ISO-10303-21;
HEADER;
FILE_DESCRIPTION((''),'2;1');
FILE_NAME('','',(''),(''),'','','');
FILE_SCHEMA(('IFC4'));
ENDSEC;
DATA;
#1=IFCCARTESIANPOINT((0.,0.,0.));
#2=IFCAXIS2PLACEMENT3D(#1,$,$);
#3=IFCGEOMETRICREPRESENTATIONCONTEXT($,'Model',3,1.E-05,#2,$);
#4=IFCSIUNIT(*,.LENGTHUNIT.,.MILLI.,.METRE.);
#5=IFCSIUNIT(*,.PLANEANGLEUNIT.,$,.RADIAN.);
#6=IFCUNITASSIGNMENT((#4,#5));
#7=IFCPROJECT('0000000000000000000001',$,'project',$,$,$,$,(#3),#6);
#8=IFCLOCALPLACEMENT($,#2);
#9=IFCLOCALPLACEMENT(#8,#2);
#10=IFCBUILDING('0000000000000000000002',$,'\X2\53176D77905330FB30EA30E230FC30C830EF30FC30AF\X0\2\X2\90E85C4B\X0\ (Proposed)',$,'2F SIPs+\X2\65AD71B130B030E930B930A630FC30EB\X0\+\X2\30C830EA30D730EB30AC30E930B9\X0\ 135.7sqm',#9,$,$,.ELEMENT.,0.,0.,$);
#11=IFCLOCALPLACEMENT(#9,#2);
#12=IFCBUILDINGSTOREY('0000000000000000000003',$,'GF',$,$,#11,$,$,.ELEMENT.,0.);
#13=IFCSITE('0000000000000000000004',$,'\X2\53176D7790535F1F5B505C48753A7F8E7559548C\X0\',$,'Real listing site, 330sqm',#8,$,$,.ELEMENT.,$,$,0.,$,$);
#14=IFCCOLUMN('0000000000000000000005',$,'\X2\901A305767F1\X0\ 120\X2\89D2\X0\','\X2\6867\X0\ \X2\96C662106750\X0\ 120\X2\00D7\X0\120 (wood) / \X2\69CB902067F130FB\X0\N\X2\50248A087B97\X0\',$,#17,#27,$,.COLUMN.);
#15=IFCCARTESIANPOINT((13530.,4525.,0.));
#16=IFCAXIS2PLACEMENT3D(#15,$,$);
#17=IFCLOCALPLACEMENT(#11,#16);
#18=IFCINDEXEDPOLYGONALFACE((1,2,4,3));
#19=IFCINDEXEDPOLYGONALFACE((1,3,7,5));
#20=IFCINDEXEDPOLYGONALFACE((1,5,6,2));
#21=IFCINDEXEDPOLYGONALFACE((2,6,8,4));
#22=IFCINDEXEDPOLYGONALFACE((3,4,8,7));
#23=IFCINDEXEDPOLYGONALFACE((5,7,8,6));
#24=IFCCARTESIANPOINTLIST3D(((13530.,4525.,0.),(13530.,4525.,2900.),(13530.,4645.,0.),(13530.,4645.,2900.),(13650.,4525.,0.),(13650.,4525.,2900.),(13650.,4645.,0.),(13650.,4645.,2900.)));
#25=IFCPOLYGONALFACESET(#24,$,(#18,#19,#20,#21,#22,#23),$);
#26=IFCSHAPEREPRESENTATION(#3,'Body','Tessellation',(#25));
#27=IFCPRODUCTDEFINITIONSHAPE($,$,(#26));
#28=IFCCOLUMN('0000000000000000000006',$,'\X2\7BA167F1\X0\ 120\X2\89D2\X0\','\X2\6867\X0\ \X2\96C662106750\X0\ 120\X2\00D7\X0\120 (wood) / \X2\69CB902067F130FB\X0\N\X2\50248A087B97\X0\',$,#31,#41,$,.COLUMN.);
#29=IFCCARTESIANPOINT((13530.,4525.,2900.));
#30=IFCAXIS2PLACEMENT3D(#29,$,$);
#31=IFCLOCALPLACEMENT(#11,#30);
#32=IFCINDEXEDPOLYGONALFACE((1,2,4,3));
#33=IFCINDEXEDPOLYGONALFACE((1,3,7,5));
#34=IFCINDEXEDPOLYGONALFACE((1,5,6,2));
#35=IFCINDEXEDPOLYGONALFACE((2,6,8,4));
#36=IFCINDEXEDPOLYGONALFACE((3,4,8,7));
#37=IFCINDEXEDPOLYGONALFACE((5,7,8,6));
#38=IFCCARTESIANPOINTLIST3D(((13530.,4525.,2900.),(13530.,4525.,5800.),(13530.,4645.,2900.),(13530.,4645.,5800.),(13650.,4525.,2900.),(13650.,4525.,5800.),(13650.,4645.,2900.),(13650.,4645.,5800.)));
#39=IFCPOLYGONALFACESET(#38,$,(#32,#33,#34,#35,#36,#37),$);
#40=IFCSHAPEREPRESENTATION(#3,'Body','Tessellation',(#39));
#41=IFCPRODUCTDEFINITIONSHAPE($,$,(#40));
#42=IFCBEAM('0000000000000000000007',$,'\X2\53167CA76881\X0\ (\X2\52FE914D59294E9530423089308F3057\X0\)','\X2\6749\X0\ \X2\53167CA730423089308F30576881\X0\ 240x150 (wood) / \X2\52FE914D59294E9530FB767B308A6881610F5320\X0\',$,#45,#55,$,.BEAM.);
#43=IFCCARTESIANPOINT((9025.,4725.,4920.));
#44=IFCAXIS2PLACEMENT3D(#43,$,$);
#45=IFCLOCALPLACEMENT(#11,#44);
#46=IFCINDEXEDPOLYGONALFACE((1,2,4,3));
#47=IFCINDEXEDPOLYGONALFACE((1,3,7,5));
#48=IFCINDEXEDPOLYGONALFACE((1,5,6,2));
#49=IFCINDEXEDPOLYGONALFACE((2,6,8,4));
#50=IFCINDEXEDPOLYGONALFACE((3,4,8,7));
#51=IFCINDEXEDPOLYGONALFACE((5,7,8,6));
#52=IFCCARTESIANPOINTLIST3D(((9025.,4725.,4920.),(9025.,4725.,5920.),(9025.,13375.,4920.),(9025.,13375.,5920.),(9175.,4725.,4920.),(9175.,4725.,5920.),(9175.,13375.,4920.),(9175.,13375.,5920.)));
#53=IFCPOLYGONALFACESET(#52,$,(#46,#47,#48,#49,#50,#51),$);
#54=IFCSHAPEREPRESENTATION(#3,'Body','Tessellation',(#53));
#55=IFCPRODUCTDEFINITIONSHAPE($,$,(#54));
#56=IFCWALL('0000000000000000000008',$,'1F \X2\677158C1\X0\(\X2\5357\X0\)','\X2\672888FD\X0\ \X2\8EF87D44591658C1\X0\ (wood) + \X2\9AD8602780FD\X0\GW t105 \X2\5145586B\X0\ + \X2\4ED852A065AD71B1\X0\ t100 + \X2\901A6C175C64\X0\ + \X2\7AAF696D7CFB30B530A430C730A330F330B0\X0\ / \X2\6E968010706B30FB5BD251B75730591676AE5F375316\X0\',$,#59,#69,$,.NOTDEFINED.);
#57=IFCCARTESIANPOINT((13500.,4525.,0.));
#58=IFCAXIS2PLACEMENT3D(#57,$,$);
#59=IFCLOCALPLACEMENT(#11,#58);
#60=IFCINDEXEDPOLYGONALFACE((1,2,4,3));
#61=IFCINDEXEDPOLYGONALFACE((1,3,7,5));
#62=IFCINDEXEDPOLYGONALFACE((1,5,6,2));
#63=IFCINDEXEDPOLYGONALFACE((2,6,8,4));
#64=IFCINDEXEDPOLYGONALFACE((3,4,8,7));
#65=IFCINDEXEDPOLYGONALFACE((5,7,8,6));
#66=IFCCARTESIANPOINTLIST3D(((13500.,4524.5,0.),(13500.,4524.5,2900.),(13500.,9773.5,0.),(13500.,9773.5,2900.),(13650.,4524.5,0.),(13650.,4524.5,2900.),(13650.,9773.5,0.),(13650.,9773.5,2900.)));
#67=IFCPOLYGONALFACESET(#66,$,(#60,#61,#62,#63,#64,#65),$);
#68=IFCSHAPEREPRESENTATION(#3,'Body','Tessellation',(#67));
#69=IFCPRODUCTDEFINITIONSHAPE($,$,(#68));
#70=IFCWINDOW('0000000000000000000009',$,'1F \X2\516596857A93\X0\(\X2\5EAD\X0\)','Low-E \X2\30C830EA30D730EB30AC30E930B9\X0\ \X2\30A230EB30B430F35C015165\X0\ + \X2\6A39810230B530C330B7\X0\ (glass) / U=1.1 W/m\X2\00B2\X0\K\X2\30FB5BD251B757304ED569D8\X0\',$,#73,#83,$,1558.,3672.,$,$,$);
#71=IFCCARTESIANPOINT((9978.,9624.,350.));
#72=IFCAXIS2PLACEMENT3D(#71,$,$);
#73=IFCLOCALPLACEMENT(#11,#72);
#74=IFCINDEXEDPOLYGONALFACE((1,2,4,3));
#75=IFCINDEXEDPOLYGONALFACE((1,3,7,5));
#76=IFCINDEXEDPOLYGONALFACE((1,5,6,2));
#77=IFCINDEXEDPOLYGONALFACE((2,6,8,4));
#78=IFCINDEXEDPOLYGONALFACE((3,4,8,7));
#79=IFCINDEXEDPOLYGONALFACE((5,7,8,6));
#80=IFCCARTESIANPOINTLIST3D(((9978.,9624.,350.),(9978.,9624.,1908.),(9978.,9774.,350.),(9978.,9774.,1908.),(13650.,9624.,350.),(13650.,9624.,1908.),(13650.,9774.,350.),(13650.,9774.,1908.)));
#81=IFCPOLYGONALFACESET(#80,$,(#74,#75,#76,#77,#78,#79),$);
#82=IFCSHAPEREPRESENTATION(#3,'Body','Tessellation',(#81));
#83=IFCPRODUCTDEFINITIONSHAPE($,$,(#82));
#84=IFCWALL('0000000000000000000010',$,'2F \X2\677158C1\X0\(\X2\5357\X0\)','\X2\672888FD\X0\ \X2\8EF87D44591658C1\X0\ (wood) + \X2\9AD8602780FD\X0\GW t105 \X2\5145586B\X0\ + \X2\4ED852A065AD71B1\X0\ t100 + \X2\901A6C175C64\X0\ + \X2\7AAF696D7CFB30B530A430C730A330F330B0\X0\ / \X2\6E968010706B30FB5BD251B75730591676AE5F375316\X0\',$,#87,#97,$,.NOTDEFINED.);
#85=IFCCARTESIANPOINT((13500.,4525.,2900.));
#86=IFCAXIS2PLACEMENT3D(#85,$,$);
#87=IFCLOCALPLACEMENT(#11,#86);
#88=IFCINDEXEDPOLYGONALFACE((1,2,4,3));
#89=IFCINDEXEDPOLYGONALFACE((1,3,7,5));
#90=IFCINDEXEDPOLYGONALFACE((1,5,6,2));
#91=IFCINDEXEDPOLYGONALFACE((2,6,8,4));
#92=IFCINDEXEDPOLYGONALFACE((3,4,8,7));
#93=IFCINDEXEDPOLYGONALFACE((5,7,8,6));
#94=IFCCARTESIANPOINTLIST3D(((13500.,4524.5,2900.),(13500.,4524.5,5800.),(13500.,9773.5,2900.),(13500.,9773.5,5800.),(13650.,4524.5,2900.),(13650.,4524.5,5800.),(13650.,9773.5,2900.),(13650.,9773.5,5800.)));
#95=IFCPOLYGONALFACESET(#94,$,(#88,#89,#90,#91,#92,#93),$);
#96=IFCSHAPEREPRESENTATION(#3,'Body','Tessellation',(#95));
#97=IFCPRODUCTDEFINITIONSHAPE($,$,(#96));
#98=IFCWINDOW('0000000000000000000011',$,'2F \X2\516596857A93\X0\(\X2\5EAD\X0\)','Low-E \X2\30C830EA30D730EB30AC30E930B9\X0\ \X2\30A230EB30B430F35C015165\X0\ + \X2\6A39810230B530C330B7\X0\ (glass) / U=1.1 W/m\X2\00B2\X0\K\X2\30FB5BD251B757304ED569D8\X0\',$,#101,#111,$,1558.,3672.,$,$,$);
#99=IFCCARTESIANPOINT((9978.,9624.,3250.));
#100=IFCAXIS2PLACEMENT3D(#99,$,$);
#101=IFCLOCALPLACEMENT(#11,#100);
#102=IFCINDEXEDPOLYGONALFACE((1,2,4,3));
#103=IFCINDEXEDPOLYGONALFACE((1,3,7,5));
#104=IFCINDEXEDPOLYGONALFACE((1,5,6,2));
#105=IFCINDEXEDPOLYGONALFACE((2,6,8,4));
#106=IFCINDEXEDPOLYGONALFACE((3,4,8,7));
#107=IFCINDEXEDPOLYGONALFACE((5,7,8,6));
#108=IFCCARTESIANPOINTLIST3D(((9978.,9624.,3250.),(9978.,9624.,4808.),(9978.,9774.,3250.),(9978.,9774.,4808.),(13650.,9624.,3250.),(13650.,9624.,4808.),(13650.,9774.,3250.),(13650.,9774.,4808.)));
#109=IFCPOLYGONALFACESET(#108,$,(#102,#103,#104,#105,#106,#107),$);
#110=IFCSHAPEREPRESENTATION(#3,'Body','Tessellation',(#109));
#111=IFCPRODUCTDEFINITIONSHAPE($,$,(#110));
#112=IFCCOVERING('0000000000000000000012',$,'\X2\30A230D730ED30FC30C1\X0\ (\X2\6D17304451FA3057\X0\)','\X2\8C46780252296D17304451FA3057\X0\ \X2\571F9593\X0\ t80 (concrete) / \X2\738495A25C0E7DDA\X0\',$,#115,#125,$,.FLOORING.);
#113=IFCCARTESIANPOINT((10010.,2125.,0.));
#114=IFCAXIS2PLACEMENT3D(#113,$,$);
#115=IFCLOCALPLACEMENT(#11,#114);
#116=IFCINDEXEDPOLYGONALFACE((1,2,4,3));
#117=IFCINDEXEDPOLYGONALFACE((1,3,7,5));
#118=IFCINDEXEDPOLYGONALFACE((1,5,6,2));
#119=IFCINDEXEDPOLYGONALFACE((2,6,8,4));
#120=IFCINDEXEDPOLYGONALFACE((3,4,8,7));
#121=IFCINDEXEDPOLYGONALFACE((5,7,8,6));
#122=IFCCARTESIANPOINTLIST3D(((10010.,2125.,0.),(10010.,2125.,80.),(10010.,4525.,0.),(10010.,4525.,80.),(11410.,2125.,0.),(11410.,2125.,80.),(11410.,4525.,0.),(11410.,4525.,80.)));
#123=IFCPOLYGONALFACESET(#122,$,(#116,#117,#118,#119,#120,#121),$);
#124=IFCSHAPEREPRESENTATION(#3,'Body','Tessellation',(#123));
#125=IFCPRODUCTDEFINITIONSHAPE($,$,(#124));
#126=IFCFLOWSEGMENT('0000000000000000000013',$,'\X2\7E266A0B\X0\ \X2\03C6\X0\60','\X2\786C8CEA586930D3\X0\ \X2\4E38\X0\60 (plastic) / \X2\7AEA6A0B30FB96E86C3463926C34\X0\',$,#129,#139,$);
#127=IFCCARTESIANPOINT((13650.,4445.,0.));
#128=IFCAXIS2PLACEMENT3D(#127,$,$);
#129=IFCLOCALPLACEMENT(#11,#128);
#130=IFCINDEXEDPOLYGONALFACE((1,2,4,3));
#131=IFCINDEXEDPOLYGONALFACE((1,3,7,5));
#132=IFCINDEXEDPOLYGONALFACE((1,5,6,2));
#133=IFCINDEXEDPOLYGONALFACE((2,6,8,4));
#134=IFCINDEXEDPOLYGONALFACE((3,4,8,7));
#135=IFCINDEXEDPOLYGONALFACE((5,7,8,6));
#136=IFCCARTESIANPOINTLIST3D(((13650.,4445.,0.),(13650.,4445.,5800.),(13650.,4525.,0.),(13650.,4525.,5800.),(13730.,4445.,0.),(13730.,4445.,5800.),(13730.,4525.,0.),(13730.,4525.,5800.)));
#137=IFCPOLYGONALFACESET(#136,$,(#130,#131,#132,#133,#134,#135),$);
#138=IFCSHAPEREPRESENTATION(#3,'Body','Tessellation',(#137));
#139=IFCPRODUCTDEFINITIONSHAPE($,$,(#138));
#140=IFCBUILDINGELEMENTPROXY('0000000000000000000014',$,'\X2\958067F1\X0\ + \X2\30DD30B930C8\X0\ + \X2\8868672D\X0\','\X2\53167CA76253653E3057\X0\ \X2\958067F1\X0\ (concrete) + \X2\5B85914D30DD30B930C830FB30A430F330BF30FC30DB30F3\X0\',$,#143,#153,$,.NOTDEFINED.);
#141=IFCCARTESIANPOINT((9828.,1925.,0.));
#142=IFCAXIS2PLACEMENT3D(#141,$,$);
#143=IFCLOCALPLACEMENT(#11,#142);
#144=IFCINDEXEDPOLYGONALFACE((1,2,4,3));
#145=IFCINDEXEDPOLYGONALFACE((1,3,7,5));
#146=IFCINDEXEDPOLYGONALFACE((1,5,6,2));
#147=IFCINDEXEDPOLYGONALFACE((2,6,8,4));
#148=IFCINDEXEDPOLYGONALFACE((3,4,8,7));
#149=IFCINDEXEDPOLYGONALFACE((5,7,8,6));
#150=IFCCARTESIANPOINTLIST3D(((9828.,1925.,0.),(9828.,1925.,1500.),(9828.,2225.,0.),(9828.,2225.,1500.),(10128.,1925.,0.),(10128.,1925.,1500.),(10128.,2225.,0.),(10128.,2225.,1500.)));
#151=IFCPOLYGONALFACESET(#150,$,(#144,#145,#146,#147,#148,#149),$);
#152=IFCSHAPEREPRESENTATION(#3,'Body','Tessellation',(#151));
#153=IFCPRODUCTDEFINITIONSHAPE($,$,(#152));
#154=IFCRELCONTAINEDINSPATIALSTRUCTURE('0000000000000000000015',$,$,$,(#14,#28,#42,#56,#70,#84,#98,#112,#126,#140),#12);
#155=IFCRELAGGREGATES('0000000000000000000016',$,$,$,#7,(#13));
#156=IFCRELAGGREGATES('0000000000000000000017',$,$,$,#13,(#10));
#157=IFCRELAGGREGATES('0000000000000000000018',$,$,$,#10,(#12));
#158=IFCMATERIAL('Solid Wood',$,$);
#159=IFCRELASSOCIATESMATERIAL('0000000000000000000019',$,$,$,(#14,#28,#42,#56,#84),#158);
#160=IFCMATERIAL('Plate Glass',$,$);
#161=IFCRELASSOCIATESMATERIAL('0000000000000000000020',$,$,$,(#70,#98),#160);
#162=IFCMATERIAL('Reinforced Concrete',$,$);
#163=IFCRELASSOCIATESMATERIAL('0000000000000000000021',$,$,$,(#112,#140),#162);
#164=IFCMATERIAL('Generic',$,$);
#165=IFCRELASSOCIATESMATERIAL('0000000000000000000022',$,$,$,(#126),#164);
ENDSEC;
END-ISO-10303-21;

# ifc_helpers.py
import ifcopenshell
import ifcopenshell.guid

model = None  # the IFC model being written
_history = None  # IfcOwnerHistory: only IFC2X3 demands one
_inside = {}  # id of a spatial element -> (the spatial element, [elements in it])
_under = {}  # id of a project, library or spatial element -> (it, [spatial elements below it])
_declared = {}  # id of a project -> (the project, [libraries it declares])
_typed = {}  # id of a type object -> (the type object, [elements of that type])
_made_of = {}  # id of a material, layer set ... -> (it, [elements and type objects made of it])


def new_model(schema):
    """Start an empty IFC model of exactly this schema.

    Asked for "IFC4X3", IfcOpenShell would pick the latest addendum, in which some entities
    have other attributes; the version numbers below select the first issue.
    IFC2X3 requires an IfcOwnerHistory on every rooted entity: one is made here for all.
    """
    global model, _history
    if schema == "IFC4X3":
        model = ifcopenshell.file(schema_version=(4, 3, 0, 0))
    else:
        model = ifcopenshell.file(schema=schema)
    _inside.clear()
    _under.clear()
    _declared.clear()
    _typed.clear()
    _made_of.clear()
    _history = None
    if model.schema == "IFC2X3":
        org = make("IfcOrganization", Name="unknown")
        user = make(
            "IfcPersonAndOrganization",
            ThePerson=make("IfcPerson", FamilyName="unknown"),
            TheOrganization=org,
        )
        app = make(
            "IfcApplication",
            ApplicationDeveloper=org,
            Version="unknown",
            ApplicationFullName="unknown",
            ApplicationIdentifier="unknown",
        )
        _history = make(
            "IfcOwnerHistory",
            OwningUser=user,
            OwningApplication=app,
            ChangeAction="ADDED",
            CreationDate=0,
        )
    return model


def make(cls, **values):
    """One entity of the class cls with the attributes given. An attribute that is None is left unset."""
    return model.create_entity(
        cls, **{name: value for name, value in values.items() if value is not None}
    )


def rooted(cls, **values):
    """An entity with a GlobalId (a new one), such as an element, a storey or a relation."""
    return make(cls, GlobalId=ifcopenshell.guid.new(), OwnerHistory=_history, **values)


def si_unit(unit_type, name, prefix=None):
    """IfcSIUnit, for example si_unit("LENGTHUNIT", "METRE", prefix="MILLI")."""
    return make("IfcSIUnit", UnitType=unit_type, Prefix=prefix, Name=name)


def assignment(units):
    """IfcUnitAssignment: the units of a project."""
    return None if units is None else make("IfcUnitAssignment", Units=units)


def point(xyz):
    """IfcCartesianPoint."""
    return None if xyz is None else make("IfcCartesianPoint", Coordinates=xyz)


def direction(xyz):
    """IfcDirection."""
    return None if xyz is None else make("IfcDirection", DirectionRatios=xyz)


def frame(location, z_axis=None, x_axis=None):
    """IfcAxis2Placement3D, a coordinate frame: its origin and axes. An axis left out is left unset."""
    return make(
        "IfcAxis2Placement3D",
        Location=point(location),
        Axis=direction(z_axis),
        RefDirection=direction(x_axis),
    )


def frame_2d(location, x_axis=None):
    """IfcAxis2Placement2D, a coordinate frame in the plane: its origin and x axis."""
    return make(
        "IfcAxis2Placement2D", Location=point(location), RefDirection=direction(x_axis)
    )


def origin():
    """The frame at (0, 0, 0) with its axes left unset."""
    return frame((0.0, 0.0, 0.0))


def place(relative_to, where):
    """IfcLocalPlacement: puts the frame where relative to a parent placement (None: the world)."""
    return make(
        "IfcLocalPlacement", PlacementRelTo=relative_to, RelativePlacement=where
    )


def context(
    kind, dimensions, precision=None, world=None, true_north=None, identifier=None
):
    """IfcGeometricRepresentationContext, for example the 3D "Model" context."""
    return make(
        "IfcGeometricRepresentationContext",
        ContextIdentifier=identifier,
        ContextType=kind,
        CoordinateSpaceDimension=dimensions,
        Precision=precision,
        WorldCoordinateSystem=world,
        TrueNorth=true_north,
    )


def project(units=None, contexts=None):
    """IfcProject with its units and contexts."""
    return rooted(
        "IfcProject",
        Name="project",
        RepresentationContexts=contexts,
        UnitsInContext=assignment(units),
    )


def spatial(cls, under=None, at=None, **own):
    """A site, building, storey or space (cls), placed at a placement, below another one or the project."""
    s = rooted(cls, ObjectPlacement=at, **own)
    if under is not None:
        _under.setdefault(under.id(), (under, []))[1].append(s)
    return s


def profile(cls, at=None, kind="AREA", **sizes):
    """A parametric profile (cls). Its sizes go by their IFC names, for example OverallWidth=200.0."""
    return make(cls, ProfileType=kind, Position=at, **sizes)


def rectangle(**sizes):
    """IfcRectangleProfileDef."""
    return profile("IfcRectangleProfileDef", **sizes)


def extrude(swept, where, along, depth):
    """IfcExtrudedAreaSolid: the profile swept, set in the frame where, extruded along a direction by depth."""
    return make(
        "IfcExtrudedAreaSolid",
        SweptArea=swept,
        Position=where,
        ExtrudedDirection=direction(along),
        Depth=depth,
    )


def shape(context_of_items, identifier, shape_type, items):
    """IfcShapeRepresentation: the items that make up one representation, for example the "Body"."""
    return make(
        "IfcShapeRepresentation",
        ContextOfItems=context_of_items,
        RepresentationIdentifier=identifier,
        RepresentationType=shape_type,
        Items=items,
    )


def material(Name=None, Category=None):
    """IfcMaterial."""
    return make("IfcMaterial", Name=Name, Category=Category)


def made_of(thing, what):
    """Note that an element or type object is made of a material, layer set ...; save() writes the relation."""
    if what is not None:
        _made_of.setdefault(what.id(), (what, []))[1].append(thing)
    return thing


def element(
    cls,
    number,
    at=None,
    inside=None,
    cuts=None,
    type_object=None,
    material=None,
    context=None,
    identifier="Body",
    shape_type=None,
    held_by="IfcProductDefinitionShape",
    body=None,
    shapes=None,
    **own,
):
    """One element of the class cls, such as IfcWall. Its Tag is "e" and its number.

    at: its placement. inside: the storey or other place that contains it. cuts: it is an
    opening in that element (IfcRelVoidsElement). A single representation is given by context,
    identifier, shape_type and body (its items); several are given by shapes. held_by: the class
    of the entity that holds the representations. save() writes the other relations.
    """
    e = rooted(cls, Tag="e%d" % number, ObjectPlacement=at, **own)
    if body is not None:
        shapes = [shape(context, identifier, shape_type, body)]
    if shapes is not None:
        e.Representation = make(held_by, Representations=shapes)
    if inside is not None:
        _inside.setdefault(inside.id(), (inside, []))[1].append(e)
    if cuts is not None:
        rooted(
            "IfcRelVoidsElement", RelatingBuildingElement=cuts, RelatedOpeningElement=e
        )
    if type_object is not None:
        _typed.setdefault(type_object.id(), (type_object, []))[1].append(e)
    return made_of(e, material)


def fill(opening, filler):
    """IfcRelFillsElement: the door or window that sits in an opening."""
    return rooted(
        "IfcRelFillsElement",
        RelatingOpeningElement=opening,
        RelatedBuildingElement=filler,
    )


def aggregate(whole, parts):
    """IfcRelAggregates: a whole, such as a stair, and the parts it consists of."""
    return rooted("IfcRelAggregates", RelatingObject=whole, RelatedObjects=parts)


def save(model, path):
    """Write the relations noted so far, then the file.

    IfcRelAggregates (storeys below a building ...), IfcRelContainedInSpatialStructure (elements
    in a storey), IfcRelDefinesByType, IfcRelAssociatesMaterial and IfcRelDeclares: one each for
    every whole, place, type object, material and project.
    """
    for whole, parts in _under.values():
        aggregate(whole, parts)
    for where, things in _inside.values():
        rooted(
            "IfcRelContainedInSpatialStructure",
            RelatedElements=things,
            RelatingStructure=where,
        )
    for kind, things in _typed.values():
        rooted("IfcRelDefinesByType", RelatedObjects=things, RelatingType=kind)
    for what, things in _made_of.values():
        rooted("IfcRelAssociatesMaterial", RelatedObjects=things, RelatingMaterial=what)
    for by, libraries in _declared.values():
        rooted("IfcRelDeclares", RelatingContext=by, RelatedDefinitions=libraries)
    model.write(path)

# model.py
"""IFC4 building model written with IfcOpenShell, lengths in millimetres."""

from ifc_helpers import new_model, si_unit, frame, frame_2d, origin, place, context, project, spatial, rectangle, extrude, material, element, fill, save


model = new_model("IFC4")

# Units and contexts
model_context = context("Model", 3, precision=1e-05, world=origin())
ifc_project = project(units=[si_unit("LENGTHUNIT", "METRE", prefix="MILLI"), si_unit("PLANEANGLEUNIT", "RADIAN")], contexts=[model_context])

# Site, building, storey
site_placement = place(None, origin())
site = spatial("IfcSite", under=ifc_project, at=site_placement, Name="北海道弟子屈町美留和", ObjectType="Real listing site, 330sqm", CompositionType="ELEMENT", RefElevation=0.0)
building_placement = place(site_placement, origin())
building = spatial("IfcBuilding", under=site, at=building_placement, Name="北海道・リモートワーク2部屋 (Proposed)", ObjectType="2F SIPs+断熱グラスウール+トリプルガラス 135.7sqm", CompositionType="ELEMENT", ElevationOfRefHeight=0.0, ElevationOfTerrain=0.0)
storey_placement = place(building_placement, origin())
storey = spatial("IfcBuildingStorey", under=building, at=storey_placement, Name="GF", CompositionType="ELEMENT", Elevation=0.0)

# Columns
ifc_material_1 = material(Name="Solid Wood")
column_1_placement = place(storey_placement, frame((13530.0, 4525.0, 0.0)))
element("IfcColumn", 1, at=column_1_placement, inside=storey, material=ifc_material_1, Name="通し柱 120角", Description="桧 集成材 120×120 (wood) / 構造柱・N値計算", PredefinedType="COLUMN", context=model_context, shape_type="SweptSolid", body=[
    extrude(rectangle(XDim=120.0, YDim=120.0, at=frame_2d((60.0, 60.0))), frame((13530.0, 4525.0, 0.0)), (0.0, 0.0, 1.0), 2900.0),
])
column_2_placement = place(storey_placement, frame((13530.0, 4525.0, 2900.0)))
element("IfcColumn", 2, at=column_2_placement, inside=storey, material=ifc_material_1, Name="管柱 120角", Description="桧 集成材 120×120 (wood) / 構造柱・N値計算", PredefinedType="COLUMN", context=model_context, shape_type="SweptSolid", body=[
    extrude(rectangle(XDim=120.0, YDim=120.0, at=frame_2d((60.0, 60.0))), frame((13530.0, 4525.0, 2900.0)), (0.0, 0.0, 1.0), 2900.0),
])

# Beam
beam_1_placement = place(storey_placement, frame((9025.0, 4725.0, 4920.0)))
element("IfcBeam", 3, at=beam_1_placement, inside=storey, material=ifc_material_1, Name="化粧梁 (勾配天井あらわし)", Description="杉 化粧あらわし梁 240x150 (wood) / 勾配天井・登り梁意匠", PredefinedType="BEAM", context=model_context, shape_type="SweptSolid", body=[
    extrude(rectangle(XDim=150.0, YDim=8650.0, at=frame_2d((75.0, 4325.0))), frame((9025.0, 4725.0, 4920.0)), (0.0, 0.0, 1.0), 1000.0),
])

# Wall, opening, window
wall_1_placement = place(storey_placement, frame((13500.0, 4525.0, 0.0)))
wall_1 = element("IfcWall", 4, at=wall_1_placement, inside=storey, material=ifc_material_1, Name="1F 東壁(南)", Description="木製 軸組外壁 (wood) + 高性能GW t105 充填 + 付加断熱 t100 + 通気層 + 窯業系サイディング / 準耐火・寒冷地外皮強化", PredefinedType="NOTDEFINED", context=model_context, shape_type="SweptSolid", body=[
    extrude(rectangle(XDim=150.0, YDim=5249.0, at=frame_2d((75.0, 2624.0))), frame((13500.0, 4525.0, 0.0)), (0.0, 0.0, 1.0), 2900.0),
])
opening_1_placement = place(storey_placement, frame((9978.0, 9624.0, 350.0)))
opening_1 = element("IfcOpeningElement", 5, at=opening_1_placement, cuts=wall_1, PredefinedType="NOTDEFINED", context=model_context, shape_type="SweptSolid", body=[
    extrude(rectangle(XDim=3672.0, YDim=150.0, at=frame_2d((1836.0, 75.0))), frame((9978.0, 9624.0, 350.0)), (0.0, 0.0, 1.0), 1558.0),
])
ifc_material_2 = material(Name="Plate Glass")
window_1_placement = place(storey_placement, frame((9978.0, 9624.0, 350.0)))
window_1 = element("IfcWindow", 6, at=window_1_placement, inside=storey, material=ifc_material_2, Name="1F 入隅窓(庭)", Description="Low-E トリプルガラス アルゴン封入 + 樹脂サッシ (glass) / U=1.1 W/m²K・寒冷地仕様", OverallHeight=1558.0, OverallWidth=3672.0, context=model_context, shape_type="SweptSolid", body=[
    extrude(rectangle(XDim=3672.0, YDim=150.0, at=frame_2d((1836.0, 75.0))), frame((9978.0, 9624.0, 350.0)), (0.0, 0.0, 1.0), 1558.0),
])
fill(opening_1, window_1)

# Wall, opening, window
wall_2_placement = place(storey_placement, frame((13500.0, 4525.0, 2900.0)))
wall_2 = element("IfcWall", 7, at=wall_2_placement, inside=storey, material=ifc_material_1, Name="2F 東壁(南)", Description="木製 軸組外壁 (wood) + 高性能GW t105 充填 + 付加断熱 t100 + 通気層 + 窯業系サイディング / 準耐火・寒冷地外皮強化", PredefinedType="NOTDEFINED", context=model_context, shape_type="SweptSolid", body=[
    extrude(rectangle(XDim=150.0, YDim=5249.0, at=frame_2d((75.0, 2624.0))), frame((13500.0, 4525.0, 2900.0)), (0.0, 0.0, 1.0), 2900.0),
])
opening_2_placement = place(storey_placement, frame((9978.0, 9624.0, 3250.0)))
opening_2 = element("IfcOpeningElement", 8, at=opening_2_placement, cuts=wall_2, PredefinedType="NOTDEFINED", context=model_context, shape_type="SweptSolid", body=[
    extrude(rectangle(XDim=3672.0, YDim=150.0, at=frame_2d((1836.0, 75.0))), frame((9978.0, 9624.0, 3250.0)), (0.0, 0.0, 1.0), 1558.0),
])
window_2_placement = place(storey_placement, frame((9978.0, 9624.0, 3250.0)))
window_2 = element("IfcWindow", 9, at=window_2_placement, inside=storey, material=ifc_material_2, Name="2F 入隅窓(庭)", Description="Low-E トリプルガラス アルゴン封入 + 樹脂サッシ (glass) / U=1.1 W/m²K・寒冷地仕様", OverallHeight=1558.0, OverallWidth=3672.0, context=model_context, shape_type="SweptSolid", body=[
    extrude(rectangle(XDim=3672.0, YDim=150.0, at=frame_2d((1836.0, 75.0))), frame((9978.0, 9624.0, 3250.0)), (0.0, 0.0, 1.0), 1558.0),
])
fill(opening_2, window_2)

# Covering
ifc_material_3 = material(Name="Reinforced Concrete")
covering_placement = place(storey_placement, frame((10010.0, 2125.0, 0.0)))
element("IfcCovering", 10, at=covering_placement, inside=storey, material=ifc_material_3, Name="アプローチ (洗い出し)", Description="豆砂利洗い出し 土間 t80 (concrete) / 玄関導線", PredefinedType="FLOORING", context=model_context, shape_type="SweptSolid", body=[
    extrude(rectangle(XDim=1400.0, YDim=2400.0, at=frame_2d((700.0, 1200.0))), frame((10010.0, 2125.0, 0.0)), (0.0, 0.0, 1.0), 80.0),
])

# Flow segment
ifc_material_4 = material(Name="Generic")
flow_segment_placement = place(storey_placement, frame((13650.0, 4445.0, 0.0)))
element("IfcFlowSegment", 11, at=flow_segment_placement, inside=storey, material=ifc_material_4, Name="縦樋 φ60", Description="硬質塩ビ 丸60 (plastic) / 竪樋・雨水排水", context=model_context, shape_type="SweptSolid", body=[
    extrude(rectangle(XDim=80.0, YDim=80.0, at=frame_2d((40.0, 40.0))), frame((13650.0, 4445.0, 0.0)), (0.0, 0.0, 1.0), 5800.0),
])

# Building element proxy
proxy_placement = place(storey_placement, frame((9828.0, 1925.0, 0.0)))
element("IfcBuildingElementProxy", 12, at=proxy_placement, inside=storey, material=ifc_material_3, Name="門柱 + ポスト + 表札", Description="化粧打放し 門柱 (concrete) + 宅配ポスト・インターホン", PredefinedType="NOTDEFINED", context=model_context, shape_type="SweptSolid", body=[
    extrude(rectangle(XDim=300.0, YDim=300.0, at=frame_2d((150.0, 150.0))), frame((9828.0, 1925.0, 0.0)), (0.0, 0.0, 1.0), 1500.0),
])

save(model, "model.ifc")
